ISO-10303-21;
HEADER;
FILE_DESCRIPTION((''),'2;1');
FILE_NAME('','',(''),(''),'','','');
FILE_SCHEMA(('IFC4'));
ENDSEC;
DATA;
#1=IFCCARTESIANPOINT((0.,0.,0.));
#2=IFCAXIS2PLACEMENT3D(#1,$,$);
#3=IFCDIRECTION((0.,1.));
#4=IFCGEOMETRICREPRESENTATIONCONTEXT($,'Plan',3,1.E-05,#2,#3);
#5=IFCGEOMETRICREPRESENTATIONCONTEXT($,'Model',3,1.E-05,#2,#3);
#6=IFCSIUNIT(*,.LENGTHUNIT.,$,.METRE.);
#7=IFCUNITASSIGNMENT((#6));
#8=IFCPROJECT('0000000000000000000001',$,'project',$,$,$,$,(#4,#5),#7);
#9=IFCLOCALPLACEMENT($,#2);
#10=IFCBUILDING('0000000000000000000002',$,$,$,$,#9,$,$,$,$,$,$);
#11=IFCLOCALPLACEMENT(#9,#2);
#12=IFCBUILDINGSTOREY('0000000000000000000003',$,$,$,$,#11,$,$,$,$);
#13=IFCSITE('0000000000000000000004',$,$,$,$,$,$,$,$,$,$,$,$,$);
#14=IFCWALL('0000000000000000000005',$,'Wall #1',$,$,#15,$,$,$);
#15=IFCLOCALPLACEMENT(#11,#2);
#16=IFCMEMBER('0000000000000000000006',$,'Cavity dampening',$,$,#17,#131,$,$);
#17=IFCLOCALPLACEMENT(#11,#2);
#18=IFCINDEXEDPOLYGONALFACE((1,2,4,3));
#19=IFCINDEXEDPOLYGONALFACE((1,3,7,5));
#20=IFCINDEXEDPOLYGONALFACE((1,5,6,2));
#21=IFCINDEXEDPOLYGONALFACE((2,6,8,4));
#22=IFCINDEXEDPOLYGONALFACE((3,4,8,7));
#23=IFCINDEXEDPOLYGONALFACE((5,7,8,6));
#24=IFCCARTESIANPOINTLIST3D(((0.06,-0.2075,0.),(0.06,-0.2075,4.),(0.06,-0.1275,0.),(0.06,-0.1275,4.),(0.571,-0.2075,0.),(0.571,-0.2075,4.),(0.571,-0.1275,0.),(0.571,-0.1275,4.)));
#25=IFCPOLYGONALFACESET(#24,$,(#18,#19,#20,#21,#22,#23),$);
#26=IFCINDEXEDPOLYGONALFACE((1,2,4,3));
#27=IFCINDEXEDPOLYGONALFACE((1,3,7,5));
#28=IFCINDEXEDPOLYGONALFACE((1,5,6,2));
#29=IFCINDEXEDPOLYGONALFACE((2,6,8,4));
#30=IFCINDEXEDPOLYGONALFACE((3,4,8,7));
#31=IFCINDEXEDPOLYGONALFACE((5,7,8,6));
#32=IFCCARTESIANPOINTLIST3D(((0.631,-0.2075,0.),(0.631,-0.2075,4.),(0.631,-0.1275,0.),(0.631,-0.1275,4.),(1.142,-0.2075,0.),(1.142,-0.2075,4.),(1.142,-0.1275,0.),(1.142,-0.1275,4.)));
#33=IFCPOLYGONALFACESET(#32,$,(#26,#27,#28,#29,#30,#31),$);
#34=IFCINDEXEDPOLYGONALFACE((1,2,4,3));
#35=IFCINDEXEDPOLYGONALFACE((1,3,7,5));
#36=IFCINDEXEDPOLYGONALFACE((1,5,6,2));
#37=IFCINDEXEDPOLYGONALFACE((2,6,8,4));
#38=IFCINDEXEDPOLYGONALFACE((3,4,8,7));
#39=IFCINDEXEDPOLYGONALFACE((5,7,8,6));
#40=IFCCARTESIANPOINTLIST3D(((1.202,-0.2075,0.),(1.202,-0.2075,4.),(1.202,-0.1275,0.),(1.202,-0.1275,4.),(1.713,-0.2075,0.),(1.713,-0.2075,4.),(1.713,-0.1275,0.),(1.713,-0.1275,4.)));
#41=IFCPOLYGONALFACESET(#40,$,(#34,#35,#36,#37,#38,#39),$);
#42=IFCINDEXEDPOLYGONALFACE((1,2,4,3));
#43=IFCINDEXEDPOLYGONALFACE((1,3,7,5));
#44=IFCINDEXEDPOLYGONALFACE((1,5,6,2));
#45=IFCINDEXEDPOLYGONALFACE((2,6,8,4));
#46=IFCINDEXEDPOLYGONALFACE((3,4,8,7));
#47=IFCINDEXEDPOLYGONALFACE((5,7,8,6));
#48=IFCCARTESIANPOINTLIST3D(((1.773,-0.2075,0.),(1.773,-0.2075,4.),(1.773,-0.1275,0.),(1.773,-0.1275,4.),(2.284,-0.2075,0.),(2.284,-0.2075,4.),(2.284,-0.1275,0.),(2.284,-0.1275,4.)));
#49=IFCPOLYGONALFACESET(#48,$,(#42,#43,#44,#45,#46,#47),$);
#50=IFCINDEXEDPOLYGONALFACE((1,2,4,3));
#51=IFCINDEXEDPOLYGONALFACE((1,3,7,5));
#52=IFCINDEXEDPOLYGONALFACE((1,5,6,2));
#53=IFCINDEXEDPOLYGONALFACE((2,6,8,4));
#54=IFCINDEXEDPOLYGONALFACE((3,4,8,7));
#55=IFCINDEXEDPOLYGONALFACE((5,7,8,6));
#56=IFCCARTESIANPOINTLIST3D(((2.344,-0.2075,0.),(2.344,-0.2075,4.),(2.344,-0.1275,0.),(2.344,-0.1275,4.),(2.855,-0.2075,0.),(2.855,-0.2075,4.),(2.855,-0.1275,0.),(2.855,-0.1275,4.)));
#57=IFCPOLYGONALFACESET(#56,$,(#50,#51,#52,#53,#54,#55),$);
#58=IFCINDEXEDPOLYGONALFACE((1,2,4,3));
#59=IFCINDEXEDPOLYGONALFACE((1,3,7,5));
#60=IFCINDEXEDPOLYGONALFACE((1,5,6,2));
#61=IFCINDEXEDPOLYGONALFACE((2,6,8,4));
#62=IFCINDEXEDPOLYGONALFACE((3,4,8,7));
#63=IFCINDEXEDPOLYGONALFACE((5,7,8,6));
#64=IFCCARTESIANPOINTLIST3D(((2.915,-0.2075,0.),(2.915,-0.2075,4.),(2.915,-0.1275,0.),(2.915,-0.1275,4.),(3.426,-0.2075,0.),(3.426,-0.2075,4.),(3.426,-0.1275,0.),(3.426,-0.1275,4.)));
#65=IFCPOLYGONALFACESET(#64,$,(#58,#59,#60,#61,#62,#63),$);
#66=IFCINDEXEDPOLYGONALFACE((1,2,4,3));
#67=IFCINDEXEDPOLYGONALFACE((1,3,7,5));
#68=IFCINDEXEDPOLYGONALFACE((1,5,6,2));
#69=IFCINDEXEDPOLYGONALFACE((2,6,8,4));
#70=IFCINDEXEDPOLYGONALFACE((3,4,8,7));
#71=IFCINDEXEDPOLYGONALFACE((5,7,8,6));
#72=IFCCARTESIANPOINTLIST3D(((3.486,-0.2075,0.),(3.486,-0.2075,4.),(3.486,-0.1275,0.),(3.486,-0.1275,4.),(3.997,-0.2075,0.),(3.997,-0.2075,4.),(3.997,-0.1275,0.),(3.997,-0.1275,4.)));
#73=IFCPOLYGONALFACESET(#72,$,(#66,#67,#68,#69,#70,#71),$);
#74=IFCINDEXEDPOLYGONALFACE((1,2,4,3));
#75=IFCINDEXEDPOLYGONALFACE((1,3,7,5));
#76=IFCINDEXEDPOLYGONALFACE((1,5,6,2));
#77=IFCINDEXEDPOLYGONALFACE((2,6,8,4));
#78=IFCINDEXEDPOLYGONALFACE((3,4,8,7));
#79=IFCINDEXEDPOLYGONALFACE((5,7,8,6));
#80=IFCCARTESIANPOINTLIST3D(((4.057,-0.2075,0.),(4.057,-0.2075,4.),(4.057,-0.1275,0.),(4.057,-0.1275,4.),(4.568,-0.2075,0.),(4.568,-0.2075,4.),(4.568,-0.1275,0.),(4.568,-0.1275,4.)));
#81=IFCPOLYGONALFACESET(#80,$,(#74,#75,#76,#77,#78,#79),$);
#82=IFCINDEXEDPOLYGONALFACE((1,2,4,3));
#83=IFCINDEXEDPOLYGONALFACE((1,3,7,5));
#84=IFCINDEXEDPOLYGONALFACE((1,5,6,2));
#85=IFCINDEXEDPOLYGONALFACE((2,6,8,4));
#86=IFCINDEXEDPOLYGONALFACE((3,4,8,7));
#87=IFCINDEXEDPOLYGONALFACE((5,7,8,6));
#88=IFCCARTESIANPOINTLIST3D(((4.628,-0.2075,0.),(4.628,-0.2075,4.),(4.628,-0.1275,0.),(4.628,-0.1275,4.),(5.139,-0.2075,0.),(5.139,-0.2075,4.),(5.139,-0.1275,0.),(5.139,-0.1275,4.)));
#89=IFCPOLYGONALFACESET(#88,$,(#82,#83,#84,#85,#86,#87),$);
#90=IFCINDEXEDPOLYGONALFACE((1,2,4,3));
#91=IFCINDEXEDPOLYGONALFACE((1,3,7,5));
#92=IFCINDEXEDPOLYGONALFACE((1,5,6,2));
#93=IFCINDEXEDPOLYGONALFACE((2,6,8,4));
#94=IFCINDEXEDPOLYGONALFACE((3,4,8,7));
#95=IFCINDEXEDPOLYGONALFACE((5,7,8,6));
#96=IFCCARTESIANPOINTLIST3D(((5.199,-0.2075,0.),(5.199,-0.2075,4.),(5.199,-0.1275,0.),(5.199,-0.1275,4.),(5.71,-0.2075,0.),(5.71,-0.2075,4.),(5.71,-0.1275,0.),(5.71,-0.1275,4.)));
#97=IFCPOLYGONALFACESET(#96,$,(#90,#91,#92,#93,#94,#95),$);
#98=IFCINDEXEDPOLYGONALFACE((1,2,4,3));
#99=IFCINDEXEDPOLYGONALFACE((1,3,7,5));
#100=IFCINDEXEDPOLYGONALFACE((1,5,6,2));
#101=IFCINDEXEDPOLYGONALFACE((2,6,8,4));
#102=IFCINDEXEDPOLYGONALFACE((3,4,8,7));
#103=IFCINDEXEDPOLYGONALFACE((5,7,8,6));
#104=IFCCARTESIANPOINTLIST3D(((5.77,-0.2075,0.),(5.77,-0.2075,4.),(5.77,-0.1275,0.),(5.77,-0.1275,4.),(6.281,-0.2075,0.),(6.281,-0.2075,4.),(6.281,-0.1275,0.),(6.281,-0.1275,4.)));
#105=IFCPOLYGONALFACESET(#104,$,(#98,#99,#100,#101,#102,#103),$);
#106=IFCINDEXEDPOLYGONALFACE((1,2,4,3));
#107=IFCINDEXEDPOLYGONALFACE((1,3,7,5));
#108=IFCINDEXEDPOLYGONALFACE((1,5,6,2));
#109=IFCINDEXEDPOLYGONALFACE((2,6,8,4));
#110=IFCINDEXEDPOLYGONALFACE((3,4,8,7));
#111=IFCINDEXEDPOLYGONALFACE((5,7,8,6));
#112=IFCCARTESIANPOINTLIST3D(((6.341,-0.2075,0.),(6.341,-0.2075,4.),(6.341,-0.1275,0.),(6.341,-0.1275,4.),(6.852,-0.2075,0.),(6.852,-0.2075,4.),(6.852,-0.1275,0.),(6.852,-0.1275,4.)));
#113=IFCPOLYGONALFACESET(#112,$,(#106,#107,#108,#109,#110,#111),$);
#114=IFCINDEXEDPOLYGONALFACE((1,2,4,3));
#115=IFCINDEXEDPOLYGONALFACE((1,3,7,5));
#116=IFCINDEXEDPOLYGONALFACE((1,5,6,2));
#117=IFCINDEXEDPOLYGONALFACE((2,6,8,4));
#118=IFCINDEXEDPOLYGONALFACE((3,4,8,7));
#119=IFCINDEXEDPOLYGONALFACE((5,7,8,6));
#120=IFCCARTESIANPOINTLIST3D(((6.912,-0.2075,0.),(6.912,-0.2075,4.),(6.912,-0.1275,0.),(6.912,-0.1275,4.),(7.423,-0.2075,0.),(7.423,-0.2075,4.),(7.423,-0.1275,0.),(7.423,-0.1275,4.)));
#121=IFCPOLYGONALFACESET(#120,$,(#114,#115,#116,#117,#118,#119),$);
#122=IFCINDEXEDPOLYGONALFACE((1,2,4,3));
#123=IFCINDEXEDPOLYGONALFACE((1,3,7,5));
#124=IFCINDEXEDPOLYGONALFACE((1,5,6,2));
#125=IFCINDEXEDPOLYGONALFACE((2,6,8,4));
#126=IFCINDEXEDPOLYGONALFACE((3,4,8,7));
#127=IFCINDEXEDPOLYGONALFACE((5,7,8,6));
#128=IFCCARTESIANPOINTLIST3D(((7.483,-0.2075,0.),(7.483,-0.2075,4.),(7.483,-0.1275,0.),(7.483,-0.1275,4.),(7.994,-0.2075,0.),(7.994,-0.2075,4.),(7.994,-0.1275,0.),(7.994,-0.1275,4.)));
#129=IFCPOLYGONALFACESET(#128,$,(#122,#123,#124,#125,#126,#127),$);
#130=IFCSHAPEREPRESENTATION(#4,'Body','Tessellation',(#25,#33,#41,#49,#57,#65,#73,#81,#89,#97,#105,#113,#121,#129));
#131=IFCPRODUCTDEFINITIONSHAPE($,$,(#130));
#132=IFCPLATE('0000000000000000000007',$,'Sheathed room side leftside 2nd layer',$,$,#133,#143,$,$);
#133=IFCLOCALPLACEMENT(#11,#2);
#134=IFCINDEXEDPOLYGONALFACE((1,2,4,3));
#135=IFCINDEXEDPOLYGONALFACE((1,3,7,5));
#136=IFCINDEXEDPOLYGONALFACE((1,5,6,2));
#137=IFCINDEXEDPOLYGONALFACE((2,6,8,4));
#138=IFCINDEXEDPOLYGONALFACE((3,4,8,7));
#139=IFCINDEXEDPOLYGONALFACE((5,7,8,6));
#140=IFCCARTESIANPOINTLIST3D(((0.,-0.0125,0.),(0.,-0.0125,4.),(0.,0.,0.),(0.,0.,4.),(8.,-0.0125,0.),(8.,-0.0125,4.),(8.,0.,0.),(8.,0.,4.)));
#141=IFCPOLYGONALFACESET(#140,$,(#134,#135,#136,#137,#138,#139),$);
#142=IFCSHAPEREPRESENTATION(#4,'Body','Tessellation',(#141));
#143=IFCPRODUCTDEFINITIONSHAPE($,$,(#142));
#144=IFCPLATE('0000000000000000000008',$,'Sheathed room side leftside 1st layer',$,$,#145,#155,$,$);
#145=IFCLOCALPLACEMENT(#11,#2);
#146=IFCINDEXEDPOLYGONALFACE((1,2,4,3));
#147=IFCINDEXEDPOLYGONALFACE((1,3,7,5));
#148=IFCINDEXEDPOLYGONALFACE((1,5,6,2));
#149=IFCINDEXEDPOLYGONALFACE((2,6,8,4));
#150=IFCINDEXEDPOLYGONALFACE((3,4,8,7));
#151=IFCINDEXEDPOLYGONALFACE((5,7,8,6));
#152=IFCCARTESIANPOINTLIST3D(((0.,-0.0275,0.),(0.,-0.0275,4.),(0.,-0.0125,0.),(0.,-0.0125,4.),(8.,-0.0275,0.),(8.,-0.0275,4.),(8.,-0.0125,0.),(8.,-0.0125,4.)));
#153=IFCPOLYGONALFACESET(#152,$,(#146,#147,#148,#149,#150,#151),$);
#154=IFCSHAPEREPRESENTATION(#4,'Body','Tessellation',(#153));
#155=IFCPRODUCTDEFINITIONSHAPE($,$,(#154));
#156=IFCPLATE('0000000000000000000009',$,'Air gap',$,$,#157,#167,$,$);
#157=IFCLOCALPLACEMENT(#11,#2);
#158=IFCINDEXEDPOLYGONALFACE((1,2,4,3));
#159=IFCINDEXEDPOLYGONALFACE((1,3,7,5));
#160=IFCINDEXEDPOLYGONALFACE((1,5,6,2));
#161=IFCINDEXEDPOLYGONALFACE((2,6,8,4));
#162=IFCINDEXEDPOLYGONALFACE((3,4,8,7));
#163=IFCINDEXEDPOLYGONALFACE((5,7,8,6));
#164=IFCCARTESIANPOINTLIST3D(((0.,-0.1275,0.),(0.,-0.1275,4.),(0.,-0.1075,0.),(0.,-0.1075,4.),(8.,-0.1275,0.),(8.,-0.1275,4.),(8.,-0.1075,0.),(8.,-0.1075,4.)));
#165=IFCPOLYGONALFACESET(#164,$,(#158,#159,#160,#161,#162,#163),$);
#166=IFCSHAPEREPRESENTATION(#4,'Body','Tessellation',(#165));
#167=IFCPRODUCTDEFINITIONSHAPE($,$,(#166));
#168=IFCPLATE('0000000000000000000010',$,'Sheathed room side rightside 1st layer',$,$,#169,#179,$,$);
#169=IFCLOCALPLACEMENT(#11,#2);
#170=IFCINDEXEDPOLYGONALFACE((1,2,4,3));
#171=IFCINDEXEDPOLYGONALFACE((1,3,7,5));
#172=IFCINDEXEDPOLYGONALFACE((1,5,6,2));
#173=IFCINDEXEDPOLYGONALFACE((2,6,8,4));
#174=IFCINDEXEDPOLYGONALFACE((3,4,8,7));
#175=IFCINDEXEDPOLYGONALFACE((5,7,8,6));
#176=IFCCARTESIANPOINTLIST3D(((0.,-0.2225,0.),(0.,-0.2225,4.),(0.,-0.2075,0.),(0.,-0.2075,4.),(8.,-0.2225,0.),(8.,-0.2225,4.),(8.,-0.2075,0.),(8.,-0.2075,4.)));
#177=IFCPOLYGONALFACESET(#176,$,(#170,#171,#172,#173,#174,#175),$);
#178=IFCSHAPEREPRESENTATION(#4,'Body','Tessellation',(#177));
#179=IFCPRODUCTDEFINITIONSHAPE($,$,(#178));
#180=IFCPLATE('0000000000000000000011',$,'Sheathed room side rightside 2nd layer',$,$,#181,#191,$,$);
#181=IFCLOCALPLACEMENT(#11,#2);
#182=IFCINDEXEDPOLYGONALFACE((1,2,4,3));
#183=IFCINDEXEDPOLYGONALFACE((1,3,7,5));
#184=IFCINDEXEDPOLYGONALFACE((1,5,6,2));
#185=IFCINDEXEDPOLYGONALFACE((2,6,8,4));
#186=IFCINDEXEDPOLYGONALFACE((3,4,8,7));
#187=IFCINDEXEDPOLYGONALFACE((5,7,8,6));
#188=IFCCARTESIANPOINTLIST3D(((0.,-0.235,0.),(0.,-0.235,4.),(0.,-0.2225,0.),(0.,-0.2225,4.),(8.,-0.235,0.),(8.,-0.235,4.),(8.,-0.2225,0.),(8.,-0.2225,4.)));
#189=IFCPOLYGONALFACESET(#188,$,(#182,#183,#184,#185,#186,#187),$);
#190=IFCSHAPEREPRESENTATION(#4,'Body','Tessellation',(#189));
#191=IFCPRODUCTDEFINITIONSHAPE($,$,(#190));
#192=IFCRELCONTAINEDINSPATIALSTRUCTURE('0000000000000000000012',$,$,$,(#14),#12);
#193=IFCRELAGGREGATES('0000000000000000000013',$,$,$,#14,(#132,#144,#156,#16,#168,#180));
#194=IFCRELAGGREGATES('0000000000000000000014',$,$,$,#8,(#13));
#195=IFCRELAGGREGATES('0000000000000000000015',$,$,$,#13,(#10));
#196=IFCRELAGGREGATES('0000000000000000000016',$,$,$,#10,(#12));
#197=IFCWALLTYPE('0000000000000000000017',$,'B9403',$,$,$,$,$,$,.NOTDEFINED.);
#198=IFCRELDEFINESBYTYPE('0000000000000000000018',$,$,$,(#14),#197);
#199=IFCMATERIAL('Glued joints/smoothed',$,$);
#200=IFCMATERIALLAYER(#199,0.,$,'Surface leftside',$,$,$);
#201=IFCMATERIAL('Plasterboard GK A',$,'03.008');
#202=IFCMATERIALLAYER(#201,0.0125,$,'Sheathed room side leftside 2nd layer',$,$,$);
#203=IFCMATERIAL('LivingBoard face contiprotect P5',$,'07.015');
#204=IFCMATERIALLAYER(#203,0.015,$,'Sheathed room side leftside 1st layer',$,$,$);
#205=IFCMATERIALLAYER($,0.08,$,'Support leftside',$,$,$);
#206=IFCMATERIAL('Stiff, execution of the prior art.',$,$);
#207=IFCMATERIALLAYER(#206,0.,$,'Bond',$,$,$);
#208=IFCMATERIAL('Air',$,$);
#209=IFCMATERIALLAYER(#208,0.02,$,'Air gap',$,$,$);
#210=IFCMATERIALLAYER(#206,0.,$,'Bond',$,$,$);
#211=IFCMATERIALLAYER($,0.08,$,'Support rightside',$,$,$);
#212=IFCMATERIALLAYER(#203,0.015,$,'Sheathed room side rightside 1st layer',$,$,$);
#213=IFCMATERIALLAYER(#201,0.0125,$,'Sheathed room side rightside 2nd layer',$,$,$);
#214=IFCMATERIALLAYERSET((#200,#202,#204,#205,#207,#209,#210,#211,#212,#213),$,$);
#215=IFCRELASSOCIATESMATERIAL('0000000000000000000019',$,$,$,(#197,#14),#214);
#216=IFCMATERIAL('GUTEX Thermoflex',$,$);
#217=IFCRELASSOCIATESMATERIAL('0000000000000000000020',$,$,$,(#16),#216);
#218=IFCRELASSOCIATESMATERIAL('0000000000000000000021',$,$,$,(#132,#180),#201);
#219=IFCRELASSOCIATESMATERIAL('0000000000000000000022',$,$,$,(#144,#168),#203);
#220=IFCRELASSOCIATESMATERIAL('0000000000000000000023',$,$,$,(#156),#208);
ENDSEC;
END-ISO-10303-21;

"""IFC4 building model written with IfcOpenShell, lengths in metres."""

from ifc_helpers import new_model, si_unit, direction, frame, frame_2d, origin, origin_with_axes, place, context, project, spatial, rectangle, extrude, material, layer, layer_set, type_object, element, aggregate, save


model = new_model("IFC4")

# Units and contexts
plan_context = context("Plan", 3, precision=1e-05, world=origin(), true_north=direction((0.0, 1.0)))
model_context = context("Model", 3, precision=1e-05, world=origin(), true_north=direction((0.0, 1.0)))
ifc_project = project(units=[si_unit("LENGTHUNIT", "METRE")], contexts=[plan_context, model_context])

# Site, building, storey
site = spatial("IfcSite", under=ifc_project)
building_placement = place(None, origin())
building = spatial("IfcBuilding", under=site, at=building_placement)
storey_placement = place(building_placement, origin())
storey = spatial("IfcBuildingStorey", under=building, at=storey_placement)

# Wall, member, plates
ifc_material_1 = material(Name="Glued joints/smoothed")
ifc_layer_1 = layer(ifc_material_1, 0.0, Name="Surface leftside")
ifc_material_2 = material(Name="Plasterboard GK A", Category="03.008")
ifc_layer_2 = layer(ifc_material_2, 0.0125, Name="Sheathed room side leftside 2nd layer")
ifc_material_3 = material(Name="LivingBoard face contiprotect P5", Category="07.015")
ifc_layer_3 = layer(ifc_material_3, 0.015, Name="Sheathed room side leftside 1st layer")
ifc_layer_4 = layer(None, 0.08, Name="Support leftside")
ifc_material_4 = material(Name="Stiff, execution of the prior art.")
ifc_layer_5 = layer(ifc_material_4, 0.0, Name="Bond")
ifc_material_5 = material(Name="Air")
ifc_layer_6 = layer(ifc_material_5, 0.02, Name="Air gap")
ifc_layer_7 = layer(ifc_material_4, 0.0, Name="Bond")
ifc_layer_8 = layer(None, 0.08, Name="Support rightside")
ifc_layer_9 = layer(ifc_material_3, 0.015, Name="Sheathed room side rightside 1st layer")
ifc_layer_10 = layer(ifc_material_2, 0.0125, Name="Sheathed room side rightside 2nd layer")
ifc_layer_set = layer_set([ifc_layer_1, ifc_layer_2, ifc_layer_3, ifc_layer_4, ifc_layer_5, ifc_layer_6, ifc_layer_7, ifc_layer_8, ifc_layer_9, ifc_layer_10])
wall_type = type_object("IfcWallType", Name="B9403", PredefinedType="NOTDEFINED", material=ifc_layer_set)
wall_placement = place(None, frame((0.0, 0.0, 0.0), z_axis=(0.0, -1.0, 0.0), x_axis=(1.0, 0.0, 0.0)))
wall = element("IfcWall", 1, at=wall_placement, inside=storey, type_object=wall_type, material=ifc_layer_set, Name="Wall #1")
ifc_material_6 = material(Name="GUTEX Thermoflex")
member_1_placement = place(wall_placement, origin())
member_1 = element("IfcMember", 2, at=member_1_placement, material=ifc_material_6, Name="Cavity dampening", context=plan_context, shape_type="SweptSolid", body=[
    extrude(rectangle(XDim=0.511, YDim=0.08, at=frame_2d((0.2555, 0.04), x_axis=(1.0, 0.0))), frame((0.06, 4.0, 0.1275), z_axis=(0.0, -1.0, 0.0), x_axis=(1.0, 0.0, 0.0)), (0.0, 0.0, 1.0), 4.0),
    extrude(rectangle(XDim=0.511, YDim=0.08, at=frame_2d((0.2555, 0.04), x_axis=(1.0, 0.0))), frame((0.631, 4.0, 0.1275), z_axis=(0.0, -1.0, 0.0), x_axis=(1.0, 0.0, 0.0)), (0.0, 0.0, 1.0), 4.0),
    extrude(rectangle(XDim=0.511, YDim=0.08, at=frame_2d((0.2555, 0.04), x_axis=(1.0, 0.0))), frame((1.202, 4.0, 0.1275), z_axis=(0.0, -1.0, 0.0), x_axis=(1.0, 0.0, 0.0)), (0.0, 0.0, 1.0), 4.0),
    extrude(rectangle(XDim=0.511, YDim=0.08, at=frame_2d((0.2555, 0.04), x_axis=(1.0, 0.0))), frame((1.773, 4.0, 0.1275), z_axis=(0.0, -1.0, 0.0), x_axis=(1.0, 0.0, 0.0)), (0.0, 0.0, 1.0), 4.0),
    extrude(rectangle(XDim=0.511, YDim=0.08, at=frame_2d((0.2555, 0.04), x_axis=(1.0, 0.0))), frame((2.344, 4.0, 0.1275), z_axis=(0.0, -1.0, 0.0), x_axis=(1.0, 0.0, 0.0)), (0.0, 0.0, 1.0), 4.0),
    extrude(rectangle(XDim=0.511, YDim=0.08, at=frame_2d((0.2555, 0.04), x_axis=(1.0, 0.0))), frame((2.915, 4.0, 0.1275), z_axis=(0.0, -1.0, 0.0), x_axis=(1.0, 0.0, 0.0)), (0.0, 0.0, 1.0), 4.0),
    extrude(rectangle(XDim=0.511, YDim=0.08, at=frame_2d((0.2555, 0.04), x_axis=(1.0, 0.0))), frame((3.486, 4.0, 0.1275), z_axis=(0.0, -1.0, 0.0), x_axis=(1.0, 0.0, 0.0)), (0.0, 0.0, 1.0), 4.0),
    extrude(rectangle(XDim=0.511, YDim=0.08, at=frame_2d((0.2555, 0.04), x_axis=(1.0, 0.0))), frame((4.057, 4.0, 0.1275), z_axis=(0.0, -1.0, 0.0), x_axis=(1.0, 0.0, 0.0)), (0.0, 0.0, 1.0), 4.0),
    extrude(rectangle(XDim=0.511, YDim=0.08, at=frame_2d((0.2555, 0.04), x_axis=(1.0, 0.0))), frame((4.628, 4.0, 0.1275), z_axis=(0.0, -1.0, 0.0), x_axis=(1.0, 0.0, 0.0)), (0.0, 0.0, 1.0), 4.0),
    extrude(rectangle(XDim=0.511, YDim=0.08, at=frame_2d((0.2555, 0.04), x_axis=(1.0, 0.0))), frame((5.199, 4.0, 0.1275), z_axis=(0.0, -1.0, 0.0), x_axis=(1.0, 0.0, 0.0)), (0.0, 0.0, 1.0), 4.0),
    extrude(rectangle(XDim=0.511, YDim=0.08, at=frame_2d((0.2555, 0.04), x_axis=(1.0, 0.0))), frame((5.77, 4.0, 0.1275), z_axis=(0.0, -1.0, 0.0), x_axis=(1.0, 0.0, 0.0)), (0.0, 0.0, 1.0), 4.0),
    extrude(rectangle(XDim=0.511, YDim=0.08, at=frame_2d((0.2555, 0.04), x_axis=(1.0, 0.0))), frame((6.341, 4.0, 0.1275), z_axis=(0.0, -1.0, 0.0), x_axis=(1.0, 0.0, 0.0)), (0.0, 0.0, 1.0), 4.0),
    extrude(rectangle(XDim=0.511, YDim=0.08, at=frame_2d((0.2555, 0.04), x_axis=(1.0, 0.0))), frame((6.912, 4.0, 0.1275), z_axis=(0.0, -1.0, 0.0), x_axis=(1.0, 0.0, 0.0)), (0.0, 0.0, 1.0), 4.0),
    extrude(rectangle(XDim=0.511, YDim=0.08, at=frame_2d((0.2555, 0.04), x_axis=(1.0, 0.0))), frame((7.483, 4.0, 0.1275), z_axis=(0.0, -1.0, 0.0), x_axis=(1.0, 0.0, 0.0)), (0.0, 0.0, 1.0), 4.0),
])
plate_1_placement = place(wall_placement, origin())
plate_1 = element("IfcPlate", 3, at=plate_1_placement, material=ifc_material_2, Name="Sheathed room side leftside 2nd layer", context=plan_context, shape_type="SweptSolid", body=[
    extrude(rectangle(XDim=8.0, YDim=4.0, at=frame_2d((4.0, 2.0), x_axis=(1.0, 0.0))), origin_with_axes(), (0.0, 0.0, 1.0), 0.0125),
])
plate_2_placement = place(wall_placement, origin())
plate_2 = element("IfcPlate", 4, at=plate_2_placement, material=ifc_material_3, Name="Sheathed room side leftside 1st layer", context=plan_context, shape_type="SweptSolid", body=[
    extrude(rectangle(XDim=8.0, YDim=4.0, at=frame_2d((4.0, 2.0), x_axis=(1.0, 0.0))), frame((0.0, 0.0, 0.0125), z_axis=(0.0, 0.0, 1.0), x_axis=(1.0, 0.0, 0.0)), (0.0, 0.0, 1.0), 0.015),
])
plate_3_placement = place(wall_placement, origin())
plate_3 = element("IfcPlate", 5, at=plate_3_placement, material=ifc_material_5, Name="Air gap", context=plan_context, shape_type="SweptSolid", body=[
    extrude(rectangle(XDim=8.0, YDim=4.0, at=frame_2d((4.0, 2.0), x_axis=(1.0, 0.0))), frame((0.0, 0.0, 0.1075), z_axis=(0.0, 0.0, 1.0), x_axis=(1.0, 0.0, 0.0)), (0.0, 0.0, 1.0), 0.02),
])
plate_4_placement = place(wall_placement, origin())
plate_4 = element("IfcPlate", 6, at=plate_4_placement, material=ifc_material_3, Name="Sheathed room side rightside 1st layer", context=plan_context, shape_type="SweptSolid", body=[
    extrude(rectangle(XDim=8.0, YDim=4.0, at=frame_2d((4.0, 2.0), x_axis=(1.0, 0.0))), frame((0.0, 0.0, 0.2075), z_axis=(0.0, 0.0, 1.0), x_axis=(1.0, 0.0, 0.0)), (0.0, 0.0, 1.0), 0.015),
])
plate_5_placement = place(wall_placement, origin())
plate_5 = element("IfcPlate", 7, at=plate_5_placement, material=ifc_material_2, Name="Sheathed room side rightside 2nd layer", context=plan_context, shape_type="SweptSolid", body=[
    extrude(rectangle(XDim=8.0, YDim=4.0, at=frame_2d((4.0, 2.0), x_axis=(1.0, 0.0))), frame((0.0, 0.0, 0.2225), z_axis=(0.0, 0.0, 1.0), x_axis=(1.0, 0.0, 0.0)), (0.0, 0.0, 1.0), 0.0125),
])
aggregate(wall, [plate_1, plate_2, plate_3, member_1, plate_4, plate_5])

save(model, "model.ifc")
